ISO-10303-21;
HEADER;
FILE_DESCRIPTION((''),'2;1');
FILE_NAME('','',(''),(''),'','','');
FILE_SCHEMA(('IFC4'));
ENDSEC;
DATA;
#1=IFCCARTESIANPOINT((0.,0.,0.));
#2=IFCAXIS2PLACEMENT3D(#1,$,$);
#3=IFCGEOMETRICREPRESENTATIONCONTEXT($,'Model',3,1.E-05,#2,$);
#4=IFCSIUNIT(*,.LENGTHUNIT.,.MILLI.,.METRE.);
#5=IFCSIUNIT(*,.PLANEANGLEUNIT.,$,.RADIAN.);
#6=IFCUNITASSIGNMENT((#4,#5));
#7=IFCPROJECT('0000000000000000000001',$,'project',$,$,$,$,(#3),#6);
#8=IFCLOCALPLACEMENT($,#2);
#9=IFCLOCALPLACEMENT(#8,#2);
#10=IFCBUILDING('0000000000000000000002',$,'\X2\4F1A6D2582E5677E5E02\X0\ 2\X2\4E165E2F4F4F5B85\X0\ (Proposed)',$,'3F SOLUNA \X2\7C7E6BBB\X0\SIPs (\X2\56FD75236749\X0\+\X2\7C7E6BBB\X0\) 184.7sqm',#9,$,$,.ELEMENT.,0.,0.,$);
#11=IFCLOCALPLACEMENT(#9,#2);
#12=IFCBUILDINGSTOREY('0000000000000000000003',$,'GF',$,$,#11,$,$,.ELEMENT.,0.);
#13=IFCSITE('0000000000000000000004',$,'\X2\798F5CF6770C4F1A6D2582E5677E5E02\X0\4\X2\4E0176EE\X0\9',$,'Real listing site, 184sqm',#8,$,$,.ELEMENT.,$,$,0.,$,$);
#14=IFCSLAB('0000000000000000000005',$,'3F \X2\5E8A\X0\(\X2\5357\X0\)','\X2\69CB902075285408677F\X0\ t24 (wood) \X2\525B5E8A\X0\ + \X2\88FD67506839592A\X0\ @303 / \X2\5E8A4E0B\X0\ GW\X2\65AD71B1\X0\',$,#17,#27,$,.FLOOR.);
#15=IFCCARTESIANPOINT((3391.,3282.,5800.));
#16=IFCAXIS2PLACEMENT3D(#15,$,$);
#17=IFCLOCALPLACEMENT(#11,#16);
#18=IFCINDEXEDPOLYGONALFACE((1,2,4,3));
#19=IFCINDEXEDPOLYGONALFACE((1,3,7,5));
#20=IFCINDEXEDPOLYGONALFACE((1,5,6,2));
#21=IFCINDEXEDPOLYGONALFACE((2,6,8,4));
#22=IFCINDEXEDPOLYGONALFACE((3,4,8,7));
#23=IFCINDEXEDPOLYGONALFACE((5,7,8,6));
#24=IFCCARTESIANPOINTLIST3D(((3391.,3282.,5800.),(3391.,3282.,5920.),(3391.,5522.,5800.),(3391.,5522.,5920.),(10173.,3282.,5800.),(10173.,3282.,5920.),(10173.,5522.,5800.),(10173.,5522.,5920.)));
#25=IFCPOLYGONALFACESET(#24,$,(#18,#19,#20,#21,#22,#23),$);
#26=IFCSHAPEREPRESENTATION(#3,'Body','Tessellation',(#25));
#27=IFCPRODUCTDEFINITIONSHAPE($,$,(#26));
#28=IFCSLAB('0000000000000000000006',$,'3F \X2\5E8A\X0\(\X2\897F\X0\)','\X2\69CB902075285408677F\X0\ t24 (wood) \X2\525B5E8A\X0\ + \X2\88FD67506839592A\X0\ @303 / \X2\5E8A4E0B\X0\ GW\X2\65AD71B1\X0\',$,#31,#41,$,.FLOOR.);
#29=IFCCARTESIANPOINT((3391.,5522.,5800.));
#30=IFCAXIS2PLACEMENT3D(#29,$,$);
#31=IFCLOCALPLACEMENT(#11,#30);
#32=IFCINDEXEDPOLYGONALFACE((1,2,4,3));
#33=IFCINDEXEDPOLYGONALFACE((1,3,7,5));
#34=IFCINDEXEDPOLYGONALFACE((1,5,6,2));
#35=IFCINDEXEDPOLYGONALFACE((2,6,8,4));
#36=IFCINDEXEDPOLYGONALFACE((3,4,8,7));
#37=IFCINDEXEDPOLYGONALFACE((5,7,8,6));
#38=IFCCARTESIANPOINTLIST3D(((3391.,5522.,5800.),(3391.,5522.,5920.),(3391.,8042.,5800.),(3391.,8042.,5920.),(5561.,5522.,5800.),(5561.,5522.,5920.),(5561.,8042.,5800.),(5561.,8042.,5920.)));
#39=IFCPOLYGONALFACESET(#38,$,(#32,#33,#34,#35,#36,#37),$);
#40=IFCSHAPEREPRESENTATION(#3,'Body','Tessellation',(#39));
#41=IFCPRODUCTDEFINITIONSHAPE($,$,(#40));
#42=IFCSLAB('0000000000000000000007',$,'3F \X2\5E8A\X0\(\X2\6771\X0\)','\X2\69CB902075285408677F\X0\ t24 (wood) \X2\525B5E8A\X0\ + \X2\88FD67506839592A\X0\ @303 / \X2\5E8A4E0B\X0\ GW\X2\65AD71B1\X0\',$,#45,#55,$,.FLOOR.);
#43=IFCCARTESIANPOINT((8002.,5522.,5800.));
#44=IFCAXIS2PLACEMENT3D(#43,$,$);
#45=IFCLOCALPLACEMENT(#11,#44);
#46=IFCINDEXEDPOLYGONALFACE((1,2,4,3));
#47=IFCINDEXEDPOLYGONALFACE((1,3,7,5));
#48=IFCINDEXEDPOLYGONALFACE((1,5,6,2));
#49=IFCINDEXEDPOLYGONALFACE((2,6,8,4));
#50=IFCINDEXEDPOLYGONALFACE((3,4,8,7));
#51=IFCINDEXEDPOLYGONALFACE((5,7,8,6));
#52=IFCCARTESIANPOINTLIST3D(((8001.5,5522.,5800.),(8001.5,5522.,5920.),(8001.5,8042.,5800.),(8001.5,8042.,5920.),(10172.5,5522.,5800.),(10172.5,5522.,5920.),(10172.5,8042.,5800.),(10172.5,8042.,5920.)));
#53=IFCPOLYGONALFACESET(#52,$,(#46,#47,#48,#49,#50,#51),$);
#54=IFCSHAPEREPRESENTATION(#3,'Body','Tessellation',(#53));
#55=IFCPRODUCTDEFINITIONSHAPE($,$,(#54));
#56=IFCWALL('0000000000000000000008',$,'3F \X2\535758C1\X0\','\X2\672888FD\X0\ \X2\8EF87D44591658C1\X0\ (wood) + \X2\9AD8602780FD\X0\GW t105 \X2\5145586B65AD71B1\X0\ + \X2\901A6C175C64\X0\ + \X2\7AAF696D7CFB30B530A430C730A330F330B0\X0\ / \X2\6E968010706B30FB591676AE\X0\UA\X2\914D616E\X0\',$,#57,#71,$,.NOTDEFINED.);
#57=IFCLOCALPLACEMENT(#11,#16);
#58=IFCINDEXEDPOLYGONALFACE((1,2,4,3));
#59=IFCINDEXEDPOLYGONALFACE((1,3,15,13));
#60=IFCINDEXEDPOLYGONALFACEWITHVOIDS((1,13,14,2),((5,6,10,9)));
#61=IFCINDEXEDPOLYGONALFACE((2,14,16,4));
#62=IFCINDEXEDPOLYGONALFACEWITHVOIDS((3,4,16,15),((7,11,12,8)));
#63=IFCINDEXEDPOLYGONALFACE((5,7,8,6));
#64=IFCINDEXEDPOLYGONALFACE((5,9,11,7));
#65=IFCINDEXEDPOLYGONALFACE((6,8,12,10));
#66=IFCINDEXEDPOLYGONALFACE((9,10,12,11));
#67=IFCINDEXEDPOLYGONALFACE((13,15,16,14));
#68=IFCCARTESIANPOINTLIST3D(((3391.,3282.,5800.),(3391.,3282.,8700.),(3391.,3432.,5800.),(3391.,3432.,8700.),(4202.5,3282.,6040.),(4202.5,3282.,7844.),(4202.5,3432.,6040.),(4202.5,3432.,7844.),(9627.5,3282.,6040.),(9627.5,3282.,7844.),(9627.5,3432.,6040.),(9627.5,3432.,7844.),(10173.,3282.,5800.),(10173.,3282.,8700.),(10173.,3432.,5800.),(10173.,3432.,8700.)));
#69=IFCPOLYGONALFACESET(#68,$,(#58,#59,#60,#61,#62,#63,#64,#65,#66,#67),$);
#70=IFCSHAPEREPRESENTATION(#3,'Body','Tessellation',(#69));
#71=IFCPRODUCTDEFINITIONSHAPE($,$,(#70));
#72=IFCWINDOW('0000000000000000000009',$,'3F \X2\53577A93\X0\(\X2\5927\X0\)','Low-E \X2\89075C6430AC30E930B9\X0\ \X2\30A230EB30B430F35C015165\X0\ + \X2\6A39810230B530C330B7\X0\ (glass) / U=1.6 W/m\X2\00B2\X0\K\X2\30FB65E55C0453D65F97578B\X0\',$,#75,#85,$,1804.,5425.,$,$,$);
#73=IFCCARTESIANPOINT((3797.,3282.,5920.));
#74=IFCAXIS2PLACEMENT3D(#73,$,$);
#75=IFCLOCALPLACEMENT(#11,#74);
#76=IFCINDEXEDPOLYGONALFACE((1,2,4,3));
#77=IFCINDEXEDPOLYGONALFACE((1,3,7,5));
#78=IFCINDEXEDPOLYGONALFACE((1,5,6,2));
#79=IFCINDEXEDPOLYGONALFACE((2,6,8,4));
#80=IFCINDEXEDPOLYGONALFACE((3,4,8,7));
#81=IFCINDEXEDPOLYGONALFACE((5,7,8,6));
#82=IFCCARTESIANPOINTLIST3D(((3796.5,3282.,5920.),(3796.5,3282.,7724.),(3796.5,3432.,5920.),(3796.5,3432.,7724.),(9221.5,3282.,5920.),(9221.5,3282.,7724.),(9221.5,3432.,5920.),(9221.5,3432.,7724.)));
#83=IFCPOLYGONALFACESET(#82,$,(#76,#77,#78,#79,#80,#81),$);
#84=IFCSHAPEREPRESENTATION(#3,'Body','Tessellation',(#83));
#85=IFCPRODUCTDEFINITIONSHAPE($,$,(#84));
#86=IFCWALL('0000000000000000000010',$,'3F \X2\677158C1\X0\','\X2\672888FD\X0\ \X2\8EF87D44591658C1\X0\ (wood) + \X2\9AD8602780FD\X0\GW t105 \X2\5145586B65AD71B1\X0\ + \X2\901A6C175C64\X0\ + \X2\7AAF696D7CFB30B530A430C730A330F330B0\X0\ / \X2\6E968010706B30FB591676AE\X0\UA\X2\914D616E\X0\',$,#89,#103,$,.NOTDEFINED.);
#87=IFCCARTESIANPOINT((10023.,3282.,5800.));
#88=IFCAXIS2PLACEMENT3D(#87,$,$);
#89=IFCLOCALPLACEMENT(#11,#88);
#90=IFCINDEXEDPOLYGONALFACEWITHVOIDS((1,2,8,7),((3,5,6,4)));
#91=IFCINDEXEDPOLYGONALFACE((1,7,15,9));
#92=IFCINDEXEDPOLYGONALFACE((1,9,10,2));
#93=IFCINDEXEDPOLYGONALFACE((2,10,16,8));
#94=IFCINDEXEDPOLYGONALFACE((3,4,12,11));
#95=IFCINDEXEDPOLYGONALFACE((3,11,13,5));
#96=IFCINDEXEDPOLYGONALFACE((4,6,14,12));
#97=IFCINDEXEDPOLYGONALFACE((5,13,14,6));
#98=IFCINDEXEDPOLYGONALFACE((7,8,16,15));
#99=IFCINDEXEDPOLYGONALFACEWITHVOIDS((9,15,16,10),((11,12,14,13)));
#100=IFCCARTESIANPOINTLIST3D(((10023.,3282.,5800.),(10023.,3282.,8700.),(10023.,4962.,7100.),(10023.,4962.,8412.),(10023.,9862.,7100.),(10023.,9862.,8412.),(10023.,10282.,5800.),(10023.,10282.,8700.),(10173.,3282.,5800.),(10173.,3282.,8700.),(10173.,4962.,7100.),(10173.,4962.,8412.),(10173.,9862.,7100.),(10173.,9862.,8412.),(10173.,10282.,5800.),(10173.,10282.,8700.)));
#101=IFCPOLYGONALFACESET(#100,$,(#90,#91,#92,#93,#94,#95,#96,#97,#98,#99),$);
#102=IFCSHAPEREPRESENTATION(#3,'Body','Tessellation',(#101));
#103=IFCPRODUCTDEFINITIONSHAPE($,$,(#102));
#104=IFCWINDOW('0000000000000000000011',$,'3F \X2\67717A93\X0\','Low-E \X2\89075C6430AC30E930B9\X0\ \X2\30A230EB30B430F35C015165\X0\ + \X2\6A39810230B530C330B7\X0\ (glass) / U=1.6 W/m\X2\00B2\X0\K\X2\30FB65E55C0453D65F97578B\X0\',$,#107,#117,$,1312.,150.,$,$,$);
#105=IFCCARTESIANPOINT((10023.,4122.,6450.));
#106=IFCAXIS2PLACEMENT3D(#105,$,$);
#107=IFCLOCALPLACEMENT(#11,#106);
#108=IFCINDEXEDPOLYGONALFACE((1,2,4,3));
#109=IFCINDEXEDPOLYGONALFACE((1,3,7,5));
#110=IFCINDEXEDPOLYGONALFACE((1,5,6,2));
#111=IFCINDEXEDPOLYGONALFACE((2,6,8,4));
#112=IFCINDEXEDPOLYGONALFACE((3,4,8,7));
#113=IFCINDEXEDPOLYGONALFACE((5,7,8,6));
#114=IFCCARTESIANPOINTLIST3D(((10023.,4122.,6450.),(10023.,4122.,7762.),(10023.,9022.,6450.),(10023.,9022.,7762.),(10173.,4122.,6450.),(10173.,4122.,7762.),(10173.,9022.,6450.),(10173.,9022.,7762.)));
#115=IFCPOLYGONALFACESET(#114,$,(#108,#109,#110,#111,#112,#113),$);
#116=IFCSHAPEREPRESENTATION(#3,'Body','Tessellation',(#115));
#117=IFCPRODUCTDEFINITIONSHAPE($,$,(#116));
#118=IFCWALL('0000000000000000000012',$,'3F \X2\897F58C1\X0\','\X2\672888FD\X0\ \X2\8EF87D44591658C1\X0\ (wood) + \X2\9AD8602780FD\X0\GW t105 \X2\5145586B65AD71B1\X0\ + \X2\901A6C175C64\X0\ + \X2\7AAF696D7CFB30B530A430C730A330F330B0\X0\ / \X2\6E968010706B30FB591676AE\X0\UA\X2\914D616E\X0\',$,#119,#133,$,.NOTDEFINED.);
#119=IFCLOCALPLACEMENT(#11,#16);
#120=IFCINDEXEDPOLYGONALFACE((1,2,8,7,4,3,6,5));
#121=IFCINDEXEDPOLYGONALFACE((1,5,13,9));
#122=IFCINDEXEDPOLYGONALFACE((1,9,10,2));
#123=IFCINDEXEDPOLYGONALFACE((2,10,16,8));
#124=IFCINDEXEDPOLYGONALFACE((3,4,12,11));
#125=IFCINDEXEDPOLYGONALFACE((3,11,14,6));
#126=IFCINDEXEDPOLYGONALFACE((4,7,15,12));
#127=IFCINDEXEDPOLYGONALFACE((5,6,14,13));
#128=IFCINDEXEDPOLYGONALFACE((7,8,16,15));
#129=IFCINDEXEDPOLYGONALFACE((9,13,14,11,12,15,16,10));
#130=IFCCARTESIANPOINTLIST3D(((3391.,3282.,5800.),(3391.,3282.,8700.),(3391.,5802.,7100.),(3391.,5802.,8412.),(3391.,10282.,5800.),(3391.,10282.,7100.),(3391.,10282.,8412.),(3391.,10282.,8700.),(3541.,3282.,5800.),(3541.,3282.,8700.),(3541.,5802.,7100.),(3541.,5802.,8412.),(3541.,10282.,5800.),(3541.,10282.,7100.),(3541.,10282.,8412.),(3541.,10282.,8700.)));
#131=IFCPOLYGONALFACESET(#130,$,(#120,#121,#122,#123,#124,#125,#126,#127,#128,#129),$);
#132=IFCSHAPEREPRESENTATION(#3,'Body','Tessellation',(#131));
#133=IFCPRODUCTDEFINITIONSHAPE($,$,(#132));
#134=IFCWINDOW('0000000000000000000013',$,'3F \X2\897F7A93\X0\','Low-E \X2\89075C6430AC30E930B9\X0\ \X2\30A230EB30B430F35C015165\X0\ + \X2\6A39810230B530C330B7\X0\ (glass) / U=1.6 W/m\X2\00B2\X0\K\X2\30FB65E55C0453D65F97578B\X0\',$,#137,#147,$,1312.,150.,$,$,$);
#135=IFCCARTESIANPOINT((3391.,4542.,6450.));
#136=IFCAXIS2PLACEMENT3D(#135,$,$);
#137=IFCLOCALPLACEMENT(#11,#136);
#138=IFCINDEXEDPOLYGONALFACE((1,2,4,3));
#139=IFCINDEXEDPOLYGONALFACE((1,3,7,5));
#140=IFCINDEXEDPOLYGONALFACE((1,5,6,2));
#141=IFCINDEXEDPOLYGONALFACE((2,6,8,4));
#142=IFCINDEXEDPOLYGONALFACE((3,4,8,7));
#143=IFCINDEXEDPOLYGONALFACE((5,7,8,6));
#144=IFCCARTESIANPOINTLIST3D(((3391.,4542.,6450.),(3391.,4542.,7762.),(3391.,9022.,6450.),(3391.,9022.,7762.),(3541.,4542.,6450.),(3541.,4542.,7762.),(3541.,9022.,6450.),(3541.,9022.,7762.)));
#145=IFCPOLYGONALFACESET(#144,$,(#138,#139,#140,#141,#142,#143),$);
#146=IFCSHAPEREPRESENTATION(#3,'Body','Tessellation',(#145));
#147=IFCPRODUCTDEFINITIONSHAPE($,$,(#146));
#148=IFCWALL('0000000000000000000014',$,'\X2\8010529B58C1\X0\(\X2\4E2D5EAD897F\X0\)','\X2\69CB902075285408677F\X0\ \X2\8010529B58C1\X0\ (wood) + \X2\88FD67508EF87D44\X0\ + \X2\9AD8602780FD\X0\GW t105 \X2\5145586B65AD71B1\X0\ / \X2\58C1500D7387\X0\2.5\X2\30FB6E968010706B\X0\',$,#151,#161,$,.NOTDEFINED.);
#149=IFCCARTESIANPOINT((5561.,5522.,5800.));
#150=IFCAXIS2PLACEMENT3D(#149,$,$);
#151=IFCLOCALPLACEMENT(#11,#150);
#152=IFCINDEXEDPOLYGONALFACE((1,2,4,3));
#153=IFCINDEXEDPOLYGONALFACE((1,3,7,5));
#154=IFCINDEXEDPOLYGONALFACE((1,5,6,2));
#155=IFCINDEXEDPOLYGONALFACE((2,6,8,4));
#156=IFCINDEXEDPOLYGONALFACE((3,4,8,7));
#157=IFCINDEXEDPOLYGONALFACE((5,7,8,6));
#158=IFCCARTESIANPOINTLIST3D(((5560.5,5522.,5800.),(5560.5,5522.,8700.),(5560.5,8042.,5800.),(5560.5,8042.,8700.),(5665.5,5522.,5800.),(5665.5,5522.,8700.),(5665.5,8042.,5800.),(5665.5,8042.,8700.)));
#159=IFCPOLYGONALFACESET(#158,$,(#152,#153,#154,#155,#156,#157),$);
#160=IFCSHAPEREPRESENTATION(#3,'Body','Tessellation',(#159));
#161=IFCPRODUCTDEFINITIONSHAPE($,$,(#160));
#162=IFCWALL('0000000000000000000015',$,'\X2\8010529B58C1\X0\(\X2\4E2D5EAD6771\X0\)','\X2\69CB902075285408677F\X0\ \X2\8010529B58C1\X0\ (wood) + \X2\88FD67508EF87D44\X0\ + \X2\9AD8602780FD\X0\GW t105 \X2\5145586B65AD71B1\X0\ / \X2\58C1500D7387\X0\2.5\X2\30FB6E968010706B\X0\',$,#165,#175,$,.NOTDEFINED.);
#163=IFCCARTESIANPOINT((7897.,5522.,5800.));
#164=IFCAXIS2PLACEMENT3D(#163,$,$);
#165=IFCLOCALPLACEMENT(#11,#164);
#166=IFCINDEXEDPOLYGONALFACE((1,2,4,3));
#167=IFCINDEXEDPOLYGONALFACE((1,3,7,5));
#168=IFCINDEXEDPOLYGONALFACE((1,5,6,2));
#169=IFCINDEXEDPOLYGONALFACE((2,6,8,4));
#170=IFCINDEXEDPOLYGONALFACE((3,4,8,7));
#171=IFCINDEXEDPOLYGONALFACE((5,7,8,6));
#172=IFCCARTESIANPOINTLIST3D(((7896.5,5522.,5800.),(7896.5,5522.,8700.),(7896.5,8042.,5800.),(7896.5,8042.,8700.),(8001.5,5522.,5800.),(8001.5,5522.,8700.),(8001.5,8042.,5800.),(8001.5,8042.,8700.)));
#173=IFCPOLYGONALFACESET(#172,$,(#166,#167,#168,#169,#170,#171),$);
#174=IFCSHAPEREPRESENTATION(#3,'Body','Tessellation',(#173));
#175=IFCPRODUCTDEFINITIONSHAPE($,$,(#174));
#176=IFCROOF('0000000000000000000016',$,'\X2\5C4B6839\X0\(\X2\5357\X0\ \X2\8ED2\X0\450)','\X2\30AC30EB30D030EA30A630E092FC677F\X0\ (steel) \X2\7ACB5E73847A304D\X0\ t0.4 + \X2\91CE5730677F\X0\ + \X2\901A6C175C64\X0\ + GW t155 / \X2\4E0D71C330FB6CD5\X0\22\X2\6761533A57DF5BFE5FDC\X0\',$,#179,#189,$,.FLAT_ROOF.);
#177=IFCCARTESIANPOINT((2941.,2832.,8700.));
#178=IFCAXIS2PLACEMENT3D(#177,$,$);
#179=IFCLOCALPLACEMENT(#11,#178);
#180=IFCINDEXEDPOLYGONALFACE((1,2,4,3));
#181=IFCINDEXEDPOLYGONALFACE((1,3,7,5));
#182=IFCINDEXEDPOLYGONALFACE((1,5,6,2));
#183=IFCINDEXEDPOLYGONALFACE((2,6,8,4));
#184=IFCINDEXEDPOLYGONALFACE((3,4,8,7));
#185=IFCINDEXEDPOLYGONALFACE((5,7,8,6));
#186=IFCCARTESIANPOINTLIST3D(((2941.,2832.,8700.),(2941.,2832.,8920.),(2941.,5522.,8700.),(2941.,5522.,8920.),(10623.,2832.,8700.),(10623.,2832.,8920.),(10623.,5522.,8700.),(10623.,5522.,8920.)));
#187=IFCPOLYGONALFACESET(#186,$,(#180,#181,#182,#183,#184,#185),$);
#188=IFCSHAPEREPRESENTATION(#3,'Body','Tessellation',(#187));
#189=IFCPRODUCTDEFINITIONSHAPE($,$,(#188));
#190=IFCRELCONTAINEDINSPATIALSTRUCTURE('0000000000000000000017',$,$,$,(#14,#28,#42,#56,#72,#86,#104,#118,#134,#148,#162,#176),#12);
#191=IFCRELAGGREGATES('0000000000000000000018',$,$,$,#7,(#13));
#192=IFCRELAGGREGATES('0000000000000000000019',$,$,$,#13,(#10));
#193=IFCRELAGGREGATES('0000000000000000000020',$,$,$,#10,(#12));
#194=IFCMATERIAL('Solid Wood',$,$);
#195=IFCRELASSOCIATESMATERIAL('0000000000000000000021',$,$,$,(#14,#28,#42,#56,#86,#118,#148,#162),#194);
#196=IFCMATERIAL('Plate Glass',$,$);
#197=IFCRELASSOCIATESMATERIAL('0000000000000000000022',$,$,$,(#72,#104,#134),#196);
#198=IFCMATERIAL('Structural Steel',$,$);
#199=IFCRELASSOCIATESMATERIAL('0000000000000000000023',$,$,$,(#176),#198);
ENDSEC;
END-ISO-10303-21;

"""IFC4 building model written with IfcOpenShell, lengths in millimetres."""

from ifc_helpers import new_model, si_unit, frame, frame_2d, origin, place, context, project, spatial, rectangle, extrude, material, element, fill, save


model = new_model("IFC4")

# Units and contexts
model_context = context("Model", 3, precision=1e-05, world=origin())
ifc_project = project(units=[si_unit("LENGTHUNIT", "METRE", prefix="MILLI"), si_unit("PLANEANGLEUNIT", "RADIAN")], contexts=[model_context])

# Site, building, storey
site_placement = place(None, origin())
site = spatial("IfcSite", under=ifc_project, at=site_placement, Name="福島県会津若松市4丁目9", ObjectType="Real listing site, 184sqm", CompositionType="ELEMENT", RefElevation=0.0)
building_placement = place(site_placement, origin())
building = spatial("IfcBuilding", under=site, at=building_placement, Name="会津若松市 2世帯住宅 (Proposed)", ObjectType="3F SOLUNA 籾殻SIPs (国産杉+籾殻) 184.7sqm", CompositionType="ELEMENT", ElevationOfRefHeight=0.0, ElevationOfTerrain=0.0)
storey_placement = place(building_placement, origin())
storey = spatial("IfcBuildingStorey", under=building, at=storey_placement, Name="GF", CompositionType="ELEMENT", Elevation=0.0)

# Slabs
ifc_material_1 = material(Name="Solid Wood")
slab_1_placement = place(storey_placement, frame((3391.0, 3282.0, 5800.0)))
element("IfcSlab", 1, at=slab_1_placement, inside=storey, material=ifc_material_1, Name="3F 床(南)", Description="構造用合板 t24 (wood) 剛床 + 製材根太 @303 / 床下 GW断熱", PredefinedType="FLOOR", context=model_context, shape_type="SweptSolid", body=[
    extrude(rectangle(XDim=6782.0, YDim=2240.0, at=frame_2d((3391.0, 1120.0))), frame((3391.0, 3282.0, 5800.0)), (0.0, 0.0, 1.0), 120.0),
])
slab_2_placement = place(storey_placement, frame((3391.0, 5522.0, 5800.0)))
element("IfcSlab", 2, at=slab_2_placement, inside=storey, material=ifc_material_1, Name="3F 床(西)", Description="構造用合板 t24 (wood) 剛床 + 製材根太 @303 / 床下 GW断熱", PredefinedType="FLOOR", context=model_context, shape_type="SweptSolid", body=[
    extrude(rectangle(XDim=2170.0, YDim=2520.0, at=frame_2d((1085.0, 1260.0))), frame((3391.0, 5522.0, 5800.0)), (0.0, 0.0, 1.0), 120.0),
])
slab_3_placement = place(storey_placement, frame((8002.0, 5522.0, 5800.0)))
element("IfcSlab", 3, at=slab_3_placement, inside=storey, material=ifc_material_1, Name="3F 床(東)", Description="構造用合板 t24 (wood) 剛床 + 製材根太 @303 / 床下 GW断熱", PredefinedType="FLOOR", context=model_context, shape_type="SweptSolid", body=[
    extrude(rectangle(XDim=2171.0, YDim=2520.0, at=frame_2d((1085.0, 1260.0))), frame((8002.0, 5522.0, 5800.0)), (0.0, 0.0, 1.0), 120.0),
])

# Walls, openings, windows
wall_1_placement = place(storey_placement, frame((3391.0, 3282.0, 5800.0)))
wall_1 = element("IfcWall", 4, at=wall_1_placement, inside=storey, material=ifc_material_1, Name="3F 南壁", Description="木製 軸組外壁 (wood) + 高性能GW t105 充填断熱 + 通気層 + 窯業系サイディング / 準耐火・外皮UA配慮", PredefinedType="NOTDEFINED", context=model_context, shape_type="SweptSolid", body=[
    extrude(rectangle(XDim=6782.0, YDim=150.0, at=frame_2d((3391.0, 75.0))), frame((3391.0, 3282.0, 5800.0)), (0.0, 0.0, 1.0), 2900.0),
])
opening_1_placement = place(storey_placement, frame((3797.0, 3282.0, 5920.0)))
opening_1 = element("IfcOpeningElement", 5, at=opening_1_placement, cuts=wall_1, PredefinedType="NOTDEFINED", context=model_context, shape_type="SweptSolid", body=[
    extrude(rectangle(XDim=5425.0, YDim=150.0, at=frame_2d((2712.0, 75.0))), frame((3797.0, 3282.0, 5920.0)), (0.0, 0.0, 1.0), 1804.0),
])
ifc_material_2 = material(Name="Plate Glass")
window_1_placement = place(storey_placement, frame((3797.0, 3282.0, 5920.0)))
window_1 = element("IfcWindow", 6, at=window_1_placement, inside=storey, material=ifc_material_2, Name="3F 南窓(大)", Description="Low-E 複層ガラス アルゴン封入 + 樹脂サッシ (glass) / U=1.6 W/m²K・日射取得型", OverallHeight=1804.0, OverallWidth=5425.0, context=model_context, shape_type="SweptSolid", body=[
    extrude(rectangle(XDim=5425.0, YDim=150.0, at=frame_2d((2712.0, 75.0))), frame((3797.0, 3282.0, 5920.0)), (0.0, 0.0, 1.0), 1804.0),
])
fill(opening_1, window_1)
wall_2_placement = place(storey_placement, frame((10023.0, 3282.0, 5800.0)))
wall_2 = element("IfcWall", 7, at=wall_2_placement, inside=storey, material=ifc_material_1, Name="3F 東壁", Description="木製 軸組外壁 (wood) + 高性能GW t105 充填断熱 + 通気層 + 窯業系サイディング / 準耐火・外皮UA配慮", PredefinedType="NOTDEFINED", context=model_context, shape_type="SweptSolid", body=[
    extrude(rectangle(XDim=150.0, YDim=7000.0, at=frame_2d((75.0, 3500.0))), frame((10023.0, 3282.0, 5800.0)), (0.0, 0.0, 1.0), 2900.0),
])
opening_2_placement = place(storey_placement, frame((10023.0, 4122.0, 6450.0)))
opening_2 = element("IfcOpeningElement", 8, at=opening_2_placement, cuts=wall_2, PredefinedType="NOTDEFINED", context=model_context, shape_type="SweptSolid", body=[
    extrude(rectangle(XDim=150.0, YDim=4900.0, at=frame_2d((75.0, 2450.0))), frame((10023.0, 4122.0, 6450.0)), (0.0, 0.0, 1.0), 1312.0),
])
window_2_placement = place(storey_placement, frame((10023.0, 4122.0, 6450.0)))
window_2 = element("IfcWindow", 9, at=window_2_placement, inside=storey, material=ifc_material_2, Name="3F 東窓", Description="Low-E 複層ガラス アルゴン封入 + 樹脂サッシ (glass) / U=1.6 W/m²K・日射取得型", OverallHeight=1312.0, OverallWidth=150.0, context=model_context, shape_type="SweptSolid", body=[
    extrude(rectangle(XDim=150.0, YDim=4900.0, at=frame_2d((75.0, 2450.0))), frame((10023.0, 4122.0, 6450.0)), (0.0, 0.0, 1.0), 1312.0),
])
fill(opening_2, window_2)
wall_3_placement = place(storey_placement, frame((3391.0, 3282.0, 5800.0)))
wall_3 = element("IfcWall", 10, at=wall_3_placement, inside=storey, material=ifc_material_1, Name="3F 西壁", Description="木製 軸組外壁 (wood) + 高性能GW t105 充填断熱 + 通気層 + 窯業系サイディング / 準耐火・外皮UA配慮", PredefinedType="NOTDEFINED", context=model_context, shape_type="SweptSolid", body=[
    extrude(rectangle(XDim=150.0, YDim=7000.0, at=frame_2d((75.0, 3500.0))), frame((3391.0, 3282.0, 5800.0)), (0.0, 0.0, 1.0), 2900.0),
])
opening_3_placement = place(storey_placement, frame((3391.0, 4542.0, 6450.0)))
opening_3 = element("IfcOpeningElement", 11, at=opening_3_placement, cuts=wall_3, PredefinedType="NOTDEFINED", context=model_context, shape_type="SweptSolid", body=[
    extrude(rectangle(XDim=150.0, YDim=4480.0, at=frame_2d((75.0, 2240.0))), frame((3391.0, 4542.0, 6450.0)), (0.0, 0.0, 1.0), 1312.0),
])
window_3_placement = place(storey_placement, frame((3391.0, 4542.0, 6450.0)))
window_3 = element("IfcWindow", 12, at=window_3_placement, inside=storey, material=ifc_material_2, Name="3F 西窓", Description="Low-E 複層ガラス アルゴン封入 + 樹脂サッシ (glass) / U=1.6 W/m²K・日射取得型", OverallHeight=1312.0, OverallWidth=150.0, context=model_context, shape_type="SweptSolid", body=[
    extrude(rectangle(XDim=150.0, YDim=4480.0, at=frame_2d((75.0, 2240.0))), frame((3391.0, 4542.0, 6450.0)), (0.0, 0.0, 1.0), 1312.0),
])
fill(opening_3, window_3)

# Walls
wall_4_placement = place(storey_placement, frame((5561.0, 5522.0, 5800.0)))
element("IfcWall", 13, at=wall_4_placement, inside=storey, material=ifc_material_1, Name="耐力壁(中庭西)", Description="構造用合板 耐力壁 (wood) + 製材軸組 + 高性能GW t105 充填断熱 / 壁倍率2.5・準耐火", PredefinedType="NOTDEFINED", context=model_context, shape_type="SweptSolid", body=[
    extrude(rectangle(XDim=105.0, YDim=2520.0, at=frame_2d((52.0, 1260.0))), frame((5561.0, 5522.0, 5800.0)), (0.0, 0.0, 1.0), 2900.0),
])
wall_5_placement = place(storey_placement, frame((7897.0, 5522.0, 5800.0)))
element("IfcWall", 14, at=wall_5_placement, inside=storey, material=ifc_material_1, Name="耐力壁(中庭東)", Description="構造用合板 耐力壁 (wood) + 製材軸組 + 高性能GW t105 充填断熱 / 壁倍率2.5・準耐火", PredefinedType="NOTDEFINED", context=model_context, shape_type="SweptSolid", body=[
    extrude(rectangle(XDim=105.0, YDim=2520.0, at=frame_2d((52.0, 1260.0))), frame((7897.0, 5522.0, 5800.0)), (0.0, 0.0, 1.0), 2900.0),
])

# Roof
ifc_material_3 = material(Name="Structural Steel")
roof_1_placement = place(storey_placement, frame((2941.0, 2832.0, 8700.0)))
element("IfcRoof", 15, at=roof_1_placement, inside=storey, material=ifc_material_3, Name="屋根(南 軒450)", Description="ガルバリウム鋼板 (steel) 立平葺き t0.4 + 野地板 + 通気層 + GW t155 / 不燃・法22条区域対応", PredefinedType="FLAT_ROOF", context=model_context, shape_type="SweptSolid", body=[
    extrude(rectangle(XDim=7682.0, YDim=2690.0, at=frame_2d((3841.0, 1345.0))), frame((2941.0, 2832.0, 8700.0)), (0.0, 0.0, 1.0), 220.0),
])

save(model, "model.ifc")
